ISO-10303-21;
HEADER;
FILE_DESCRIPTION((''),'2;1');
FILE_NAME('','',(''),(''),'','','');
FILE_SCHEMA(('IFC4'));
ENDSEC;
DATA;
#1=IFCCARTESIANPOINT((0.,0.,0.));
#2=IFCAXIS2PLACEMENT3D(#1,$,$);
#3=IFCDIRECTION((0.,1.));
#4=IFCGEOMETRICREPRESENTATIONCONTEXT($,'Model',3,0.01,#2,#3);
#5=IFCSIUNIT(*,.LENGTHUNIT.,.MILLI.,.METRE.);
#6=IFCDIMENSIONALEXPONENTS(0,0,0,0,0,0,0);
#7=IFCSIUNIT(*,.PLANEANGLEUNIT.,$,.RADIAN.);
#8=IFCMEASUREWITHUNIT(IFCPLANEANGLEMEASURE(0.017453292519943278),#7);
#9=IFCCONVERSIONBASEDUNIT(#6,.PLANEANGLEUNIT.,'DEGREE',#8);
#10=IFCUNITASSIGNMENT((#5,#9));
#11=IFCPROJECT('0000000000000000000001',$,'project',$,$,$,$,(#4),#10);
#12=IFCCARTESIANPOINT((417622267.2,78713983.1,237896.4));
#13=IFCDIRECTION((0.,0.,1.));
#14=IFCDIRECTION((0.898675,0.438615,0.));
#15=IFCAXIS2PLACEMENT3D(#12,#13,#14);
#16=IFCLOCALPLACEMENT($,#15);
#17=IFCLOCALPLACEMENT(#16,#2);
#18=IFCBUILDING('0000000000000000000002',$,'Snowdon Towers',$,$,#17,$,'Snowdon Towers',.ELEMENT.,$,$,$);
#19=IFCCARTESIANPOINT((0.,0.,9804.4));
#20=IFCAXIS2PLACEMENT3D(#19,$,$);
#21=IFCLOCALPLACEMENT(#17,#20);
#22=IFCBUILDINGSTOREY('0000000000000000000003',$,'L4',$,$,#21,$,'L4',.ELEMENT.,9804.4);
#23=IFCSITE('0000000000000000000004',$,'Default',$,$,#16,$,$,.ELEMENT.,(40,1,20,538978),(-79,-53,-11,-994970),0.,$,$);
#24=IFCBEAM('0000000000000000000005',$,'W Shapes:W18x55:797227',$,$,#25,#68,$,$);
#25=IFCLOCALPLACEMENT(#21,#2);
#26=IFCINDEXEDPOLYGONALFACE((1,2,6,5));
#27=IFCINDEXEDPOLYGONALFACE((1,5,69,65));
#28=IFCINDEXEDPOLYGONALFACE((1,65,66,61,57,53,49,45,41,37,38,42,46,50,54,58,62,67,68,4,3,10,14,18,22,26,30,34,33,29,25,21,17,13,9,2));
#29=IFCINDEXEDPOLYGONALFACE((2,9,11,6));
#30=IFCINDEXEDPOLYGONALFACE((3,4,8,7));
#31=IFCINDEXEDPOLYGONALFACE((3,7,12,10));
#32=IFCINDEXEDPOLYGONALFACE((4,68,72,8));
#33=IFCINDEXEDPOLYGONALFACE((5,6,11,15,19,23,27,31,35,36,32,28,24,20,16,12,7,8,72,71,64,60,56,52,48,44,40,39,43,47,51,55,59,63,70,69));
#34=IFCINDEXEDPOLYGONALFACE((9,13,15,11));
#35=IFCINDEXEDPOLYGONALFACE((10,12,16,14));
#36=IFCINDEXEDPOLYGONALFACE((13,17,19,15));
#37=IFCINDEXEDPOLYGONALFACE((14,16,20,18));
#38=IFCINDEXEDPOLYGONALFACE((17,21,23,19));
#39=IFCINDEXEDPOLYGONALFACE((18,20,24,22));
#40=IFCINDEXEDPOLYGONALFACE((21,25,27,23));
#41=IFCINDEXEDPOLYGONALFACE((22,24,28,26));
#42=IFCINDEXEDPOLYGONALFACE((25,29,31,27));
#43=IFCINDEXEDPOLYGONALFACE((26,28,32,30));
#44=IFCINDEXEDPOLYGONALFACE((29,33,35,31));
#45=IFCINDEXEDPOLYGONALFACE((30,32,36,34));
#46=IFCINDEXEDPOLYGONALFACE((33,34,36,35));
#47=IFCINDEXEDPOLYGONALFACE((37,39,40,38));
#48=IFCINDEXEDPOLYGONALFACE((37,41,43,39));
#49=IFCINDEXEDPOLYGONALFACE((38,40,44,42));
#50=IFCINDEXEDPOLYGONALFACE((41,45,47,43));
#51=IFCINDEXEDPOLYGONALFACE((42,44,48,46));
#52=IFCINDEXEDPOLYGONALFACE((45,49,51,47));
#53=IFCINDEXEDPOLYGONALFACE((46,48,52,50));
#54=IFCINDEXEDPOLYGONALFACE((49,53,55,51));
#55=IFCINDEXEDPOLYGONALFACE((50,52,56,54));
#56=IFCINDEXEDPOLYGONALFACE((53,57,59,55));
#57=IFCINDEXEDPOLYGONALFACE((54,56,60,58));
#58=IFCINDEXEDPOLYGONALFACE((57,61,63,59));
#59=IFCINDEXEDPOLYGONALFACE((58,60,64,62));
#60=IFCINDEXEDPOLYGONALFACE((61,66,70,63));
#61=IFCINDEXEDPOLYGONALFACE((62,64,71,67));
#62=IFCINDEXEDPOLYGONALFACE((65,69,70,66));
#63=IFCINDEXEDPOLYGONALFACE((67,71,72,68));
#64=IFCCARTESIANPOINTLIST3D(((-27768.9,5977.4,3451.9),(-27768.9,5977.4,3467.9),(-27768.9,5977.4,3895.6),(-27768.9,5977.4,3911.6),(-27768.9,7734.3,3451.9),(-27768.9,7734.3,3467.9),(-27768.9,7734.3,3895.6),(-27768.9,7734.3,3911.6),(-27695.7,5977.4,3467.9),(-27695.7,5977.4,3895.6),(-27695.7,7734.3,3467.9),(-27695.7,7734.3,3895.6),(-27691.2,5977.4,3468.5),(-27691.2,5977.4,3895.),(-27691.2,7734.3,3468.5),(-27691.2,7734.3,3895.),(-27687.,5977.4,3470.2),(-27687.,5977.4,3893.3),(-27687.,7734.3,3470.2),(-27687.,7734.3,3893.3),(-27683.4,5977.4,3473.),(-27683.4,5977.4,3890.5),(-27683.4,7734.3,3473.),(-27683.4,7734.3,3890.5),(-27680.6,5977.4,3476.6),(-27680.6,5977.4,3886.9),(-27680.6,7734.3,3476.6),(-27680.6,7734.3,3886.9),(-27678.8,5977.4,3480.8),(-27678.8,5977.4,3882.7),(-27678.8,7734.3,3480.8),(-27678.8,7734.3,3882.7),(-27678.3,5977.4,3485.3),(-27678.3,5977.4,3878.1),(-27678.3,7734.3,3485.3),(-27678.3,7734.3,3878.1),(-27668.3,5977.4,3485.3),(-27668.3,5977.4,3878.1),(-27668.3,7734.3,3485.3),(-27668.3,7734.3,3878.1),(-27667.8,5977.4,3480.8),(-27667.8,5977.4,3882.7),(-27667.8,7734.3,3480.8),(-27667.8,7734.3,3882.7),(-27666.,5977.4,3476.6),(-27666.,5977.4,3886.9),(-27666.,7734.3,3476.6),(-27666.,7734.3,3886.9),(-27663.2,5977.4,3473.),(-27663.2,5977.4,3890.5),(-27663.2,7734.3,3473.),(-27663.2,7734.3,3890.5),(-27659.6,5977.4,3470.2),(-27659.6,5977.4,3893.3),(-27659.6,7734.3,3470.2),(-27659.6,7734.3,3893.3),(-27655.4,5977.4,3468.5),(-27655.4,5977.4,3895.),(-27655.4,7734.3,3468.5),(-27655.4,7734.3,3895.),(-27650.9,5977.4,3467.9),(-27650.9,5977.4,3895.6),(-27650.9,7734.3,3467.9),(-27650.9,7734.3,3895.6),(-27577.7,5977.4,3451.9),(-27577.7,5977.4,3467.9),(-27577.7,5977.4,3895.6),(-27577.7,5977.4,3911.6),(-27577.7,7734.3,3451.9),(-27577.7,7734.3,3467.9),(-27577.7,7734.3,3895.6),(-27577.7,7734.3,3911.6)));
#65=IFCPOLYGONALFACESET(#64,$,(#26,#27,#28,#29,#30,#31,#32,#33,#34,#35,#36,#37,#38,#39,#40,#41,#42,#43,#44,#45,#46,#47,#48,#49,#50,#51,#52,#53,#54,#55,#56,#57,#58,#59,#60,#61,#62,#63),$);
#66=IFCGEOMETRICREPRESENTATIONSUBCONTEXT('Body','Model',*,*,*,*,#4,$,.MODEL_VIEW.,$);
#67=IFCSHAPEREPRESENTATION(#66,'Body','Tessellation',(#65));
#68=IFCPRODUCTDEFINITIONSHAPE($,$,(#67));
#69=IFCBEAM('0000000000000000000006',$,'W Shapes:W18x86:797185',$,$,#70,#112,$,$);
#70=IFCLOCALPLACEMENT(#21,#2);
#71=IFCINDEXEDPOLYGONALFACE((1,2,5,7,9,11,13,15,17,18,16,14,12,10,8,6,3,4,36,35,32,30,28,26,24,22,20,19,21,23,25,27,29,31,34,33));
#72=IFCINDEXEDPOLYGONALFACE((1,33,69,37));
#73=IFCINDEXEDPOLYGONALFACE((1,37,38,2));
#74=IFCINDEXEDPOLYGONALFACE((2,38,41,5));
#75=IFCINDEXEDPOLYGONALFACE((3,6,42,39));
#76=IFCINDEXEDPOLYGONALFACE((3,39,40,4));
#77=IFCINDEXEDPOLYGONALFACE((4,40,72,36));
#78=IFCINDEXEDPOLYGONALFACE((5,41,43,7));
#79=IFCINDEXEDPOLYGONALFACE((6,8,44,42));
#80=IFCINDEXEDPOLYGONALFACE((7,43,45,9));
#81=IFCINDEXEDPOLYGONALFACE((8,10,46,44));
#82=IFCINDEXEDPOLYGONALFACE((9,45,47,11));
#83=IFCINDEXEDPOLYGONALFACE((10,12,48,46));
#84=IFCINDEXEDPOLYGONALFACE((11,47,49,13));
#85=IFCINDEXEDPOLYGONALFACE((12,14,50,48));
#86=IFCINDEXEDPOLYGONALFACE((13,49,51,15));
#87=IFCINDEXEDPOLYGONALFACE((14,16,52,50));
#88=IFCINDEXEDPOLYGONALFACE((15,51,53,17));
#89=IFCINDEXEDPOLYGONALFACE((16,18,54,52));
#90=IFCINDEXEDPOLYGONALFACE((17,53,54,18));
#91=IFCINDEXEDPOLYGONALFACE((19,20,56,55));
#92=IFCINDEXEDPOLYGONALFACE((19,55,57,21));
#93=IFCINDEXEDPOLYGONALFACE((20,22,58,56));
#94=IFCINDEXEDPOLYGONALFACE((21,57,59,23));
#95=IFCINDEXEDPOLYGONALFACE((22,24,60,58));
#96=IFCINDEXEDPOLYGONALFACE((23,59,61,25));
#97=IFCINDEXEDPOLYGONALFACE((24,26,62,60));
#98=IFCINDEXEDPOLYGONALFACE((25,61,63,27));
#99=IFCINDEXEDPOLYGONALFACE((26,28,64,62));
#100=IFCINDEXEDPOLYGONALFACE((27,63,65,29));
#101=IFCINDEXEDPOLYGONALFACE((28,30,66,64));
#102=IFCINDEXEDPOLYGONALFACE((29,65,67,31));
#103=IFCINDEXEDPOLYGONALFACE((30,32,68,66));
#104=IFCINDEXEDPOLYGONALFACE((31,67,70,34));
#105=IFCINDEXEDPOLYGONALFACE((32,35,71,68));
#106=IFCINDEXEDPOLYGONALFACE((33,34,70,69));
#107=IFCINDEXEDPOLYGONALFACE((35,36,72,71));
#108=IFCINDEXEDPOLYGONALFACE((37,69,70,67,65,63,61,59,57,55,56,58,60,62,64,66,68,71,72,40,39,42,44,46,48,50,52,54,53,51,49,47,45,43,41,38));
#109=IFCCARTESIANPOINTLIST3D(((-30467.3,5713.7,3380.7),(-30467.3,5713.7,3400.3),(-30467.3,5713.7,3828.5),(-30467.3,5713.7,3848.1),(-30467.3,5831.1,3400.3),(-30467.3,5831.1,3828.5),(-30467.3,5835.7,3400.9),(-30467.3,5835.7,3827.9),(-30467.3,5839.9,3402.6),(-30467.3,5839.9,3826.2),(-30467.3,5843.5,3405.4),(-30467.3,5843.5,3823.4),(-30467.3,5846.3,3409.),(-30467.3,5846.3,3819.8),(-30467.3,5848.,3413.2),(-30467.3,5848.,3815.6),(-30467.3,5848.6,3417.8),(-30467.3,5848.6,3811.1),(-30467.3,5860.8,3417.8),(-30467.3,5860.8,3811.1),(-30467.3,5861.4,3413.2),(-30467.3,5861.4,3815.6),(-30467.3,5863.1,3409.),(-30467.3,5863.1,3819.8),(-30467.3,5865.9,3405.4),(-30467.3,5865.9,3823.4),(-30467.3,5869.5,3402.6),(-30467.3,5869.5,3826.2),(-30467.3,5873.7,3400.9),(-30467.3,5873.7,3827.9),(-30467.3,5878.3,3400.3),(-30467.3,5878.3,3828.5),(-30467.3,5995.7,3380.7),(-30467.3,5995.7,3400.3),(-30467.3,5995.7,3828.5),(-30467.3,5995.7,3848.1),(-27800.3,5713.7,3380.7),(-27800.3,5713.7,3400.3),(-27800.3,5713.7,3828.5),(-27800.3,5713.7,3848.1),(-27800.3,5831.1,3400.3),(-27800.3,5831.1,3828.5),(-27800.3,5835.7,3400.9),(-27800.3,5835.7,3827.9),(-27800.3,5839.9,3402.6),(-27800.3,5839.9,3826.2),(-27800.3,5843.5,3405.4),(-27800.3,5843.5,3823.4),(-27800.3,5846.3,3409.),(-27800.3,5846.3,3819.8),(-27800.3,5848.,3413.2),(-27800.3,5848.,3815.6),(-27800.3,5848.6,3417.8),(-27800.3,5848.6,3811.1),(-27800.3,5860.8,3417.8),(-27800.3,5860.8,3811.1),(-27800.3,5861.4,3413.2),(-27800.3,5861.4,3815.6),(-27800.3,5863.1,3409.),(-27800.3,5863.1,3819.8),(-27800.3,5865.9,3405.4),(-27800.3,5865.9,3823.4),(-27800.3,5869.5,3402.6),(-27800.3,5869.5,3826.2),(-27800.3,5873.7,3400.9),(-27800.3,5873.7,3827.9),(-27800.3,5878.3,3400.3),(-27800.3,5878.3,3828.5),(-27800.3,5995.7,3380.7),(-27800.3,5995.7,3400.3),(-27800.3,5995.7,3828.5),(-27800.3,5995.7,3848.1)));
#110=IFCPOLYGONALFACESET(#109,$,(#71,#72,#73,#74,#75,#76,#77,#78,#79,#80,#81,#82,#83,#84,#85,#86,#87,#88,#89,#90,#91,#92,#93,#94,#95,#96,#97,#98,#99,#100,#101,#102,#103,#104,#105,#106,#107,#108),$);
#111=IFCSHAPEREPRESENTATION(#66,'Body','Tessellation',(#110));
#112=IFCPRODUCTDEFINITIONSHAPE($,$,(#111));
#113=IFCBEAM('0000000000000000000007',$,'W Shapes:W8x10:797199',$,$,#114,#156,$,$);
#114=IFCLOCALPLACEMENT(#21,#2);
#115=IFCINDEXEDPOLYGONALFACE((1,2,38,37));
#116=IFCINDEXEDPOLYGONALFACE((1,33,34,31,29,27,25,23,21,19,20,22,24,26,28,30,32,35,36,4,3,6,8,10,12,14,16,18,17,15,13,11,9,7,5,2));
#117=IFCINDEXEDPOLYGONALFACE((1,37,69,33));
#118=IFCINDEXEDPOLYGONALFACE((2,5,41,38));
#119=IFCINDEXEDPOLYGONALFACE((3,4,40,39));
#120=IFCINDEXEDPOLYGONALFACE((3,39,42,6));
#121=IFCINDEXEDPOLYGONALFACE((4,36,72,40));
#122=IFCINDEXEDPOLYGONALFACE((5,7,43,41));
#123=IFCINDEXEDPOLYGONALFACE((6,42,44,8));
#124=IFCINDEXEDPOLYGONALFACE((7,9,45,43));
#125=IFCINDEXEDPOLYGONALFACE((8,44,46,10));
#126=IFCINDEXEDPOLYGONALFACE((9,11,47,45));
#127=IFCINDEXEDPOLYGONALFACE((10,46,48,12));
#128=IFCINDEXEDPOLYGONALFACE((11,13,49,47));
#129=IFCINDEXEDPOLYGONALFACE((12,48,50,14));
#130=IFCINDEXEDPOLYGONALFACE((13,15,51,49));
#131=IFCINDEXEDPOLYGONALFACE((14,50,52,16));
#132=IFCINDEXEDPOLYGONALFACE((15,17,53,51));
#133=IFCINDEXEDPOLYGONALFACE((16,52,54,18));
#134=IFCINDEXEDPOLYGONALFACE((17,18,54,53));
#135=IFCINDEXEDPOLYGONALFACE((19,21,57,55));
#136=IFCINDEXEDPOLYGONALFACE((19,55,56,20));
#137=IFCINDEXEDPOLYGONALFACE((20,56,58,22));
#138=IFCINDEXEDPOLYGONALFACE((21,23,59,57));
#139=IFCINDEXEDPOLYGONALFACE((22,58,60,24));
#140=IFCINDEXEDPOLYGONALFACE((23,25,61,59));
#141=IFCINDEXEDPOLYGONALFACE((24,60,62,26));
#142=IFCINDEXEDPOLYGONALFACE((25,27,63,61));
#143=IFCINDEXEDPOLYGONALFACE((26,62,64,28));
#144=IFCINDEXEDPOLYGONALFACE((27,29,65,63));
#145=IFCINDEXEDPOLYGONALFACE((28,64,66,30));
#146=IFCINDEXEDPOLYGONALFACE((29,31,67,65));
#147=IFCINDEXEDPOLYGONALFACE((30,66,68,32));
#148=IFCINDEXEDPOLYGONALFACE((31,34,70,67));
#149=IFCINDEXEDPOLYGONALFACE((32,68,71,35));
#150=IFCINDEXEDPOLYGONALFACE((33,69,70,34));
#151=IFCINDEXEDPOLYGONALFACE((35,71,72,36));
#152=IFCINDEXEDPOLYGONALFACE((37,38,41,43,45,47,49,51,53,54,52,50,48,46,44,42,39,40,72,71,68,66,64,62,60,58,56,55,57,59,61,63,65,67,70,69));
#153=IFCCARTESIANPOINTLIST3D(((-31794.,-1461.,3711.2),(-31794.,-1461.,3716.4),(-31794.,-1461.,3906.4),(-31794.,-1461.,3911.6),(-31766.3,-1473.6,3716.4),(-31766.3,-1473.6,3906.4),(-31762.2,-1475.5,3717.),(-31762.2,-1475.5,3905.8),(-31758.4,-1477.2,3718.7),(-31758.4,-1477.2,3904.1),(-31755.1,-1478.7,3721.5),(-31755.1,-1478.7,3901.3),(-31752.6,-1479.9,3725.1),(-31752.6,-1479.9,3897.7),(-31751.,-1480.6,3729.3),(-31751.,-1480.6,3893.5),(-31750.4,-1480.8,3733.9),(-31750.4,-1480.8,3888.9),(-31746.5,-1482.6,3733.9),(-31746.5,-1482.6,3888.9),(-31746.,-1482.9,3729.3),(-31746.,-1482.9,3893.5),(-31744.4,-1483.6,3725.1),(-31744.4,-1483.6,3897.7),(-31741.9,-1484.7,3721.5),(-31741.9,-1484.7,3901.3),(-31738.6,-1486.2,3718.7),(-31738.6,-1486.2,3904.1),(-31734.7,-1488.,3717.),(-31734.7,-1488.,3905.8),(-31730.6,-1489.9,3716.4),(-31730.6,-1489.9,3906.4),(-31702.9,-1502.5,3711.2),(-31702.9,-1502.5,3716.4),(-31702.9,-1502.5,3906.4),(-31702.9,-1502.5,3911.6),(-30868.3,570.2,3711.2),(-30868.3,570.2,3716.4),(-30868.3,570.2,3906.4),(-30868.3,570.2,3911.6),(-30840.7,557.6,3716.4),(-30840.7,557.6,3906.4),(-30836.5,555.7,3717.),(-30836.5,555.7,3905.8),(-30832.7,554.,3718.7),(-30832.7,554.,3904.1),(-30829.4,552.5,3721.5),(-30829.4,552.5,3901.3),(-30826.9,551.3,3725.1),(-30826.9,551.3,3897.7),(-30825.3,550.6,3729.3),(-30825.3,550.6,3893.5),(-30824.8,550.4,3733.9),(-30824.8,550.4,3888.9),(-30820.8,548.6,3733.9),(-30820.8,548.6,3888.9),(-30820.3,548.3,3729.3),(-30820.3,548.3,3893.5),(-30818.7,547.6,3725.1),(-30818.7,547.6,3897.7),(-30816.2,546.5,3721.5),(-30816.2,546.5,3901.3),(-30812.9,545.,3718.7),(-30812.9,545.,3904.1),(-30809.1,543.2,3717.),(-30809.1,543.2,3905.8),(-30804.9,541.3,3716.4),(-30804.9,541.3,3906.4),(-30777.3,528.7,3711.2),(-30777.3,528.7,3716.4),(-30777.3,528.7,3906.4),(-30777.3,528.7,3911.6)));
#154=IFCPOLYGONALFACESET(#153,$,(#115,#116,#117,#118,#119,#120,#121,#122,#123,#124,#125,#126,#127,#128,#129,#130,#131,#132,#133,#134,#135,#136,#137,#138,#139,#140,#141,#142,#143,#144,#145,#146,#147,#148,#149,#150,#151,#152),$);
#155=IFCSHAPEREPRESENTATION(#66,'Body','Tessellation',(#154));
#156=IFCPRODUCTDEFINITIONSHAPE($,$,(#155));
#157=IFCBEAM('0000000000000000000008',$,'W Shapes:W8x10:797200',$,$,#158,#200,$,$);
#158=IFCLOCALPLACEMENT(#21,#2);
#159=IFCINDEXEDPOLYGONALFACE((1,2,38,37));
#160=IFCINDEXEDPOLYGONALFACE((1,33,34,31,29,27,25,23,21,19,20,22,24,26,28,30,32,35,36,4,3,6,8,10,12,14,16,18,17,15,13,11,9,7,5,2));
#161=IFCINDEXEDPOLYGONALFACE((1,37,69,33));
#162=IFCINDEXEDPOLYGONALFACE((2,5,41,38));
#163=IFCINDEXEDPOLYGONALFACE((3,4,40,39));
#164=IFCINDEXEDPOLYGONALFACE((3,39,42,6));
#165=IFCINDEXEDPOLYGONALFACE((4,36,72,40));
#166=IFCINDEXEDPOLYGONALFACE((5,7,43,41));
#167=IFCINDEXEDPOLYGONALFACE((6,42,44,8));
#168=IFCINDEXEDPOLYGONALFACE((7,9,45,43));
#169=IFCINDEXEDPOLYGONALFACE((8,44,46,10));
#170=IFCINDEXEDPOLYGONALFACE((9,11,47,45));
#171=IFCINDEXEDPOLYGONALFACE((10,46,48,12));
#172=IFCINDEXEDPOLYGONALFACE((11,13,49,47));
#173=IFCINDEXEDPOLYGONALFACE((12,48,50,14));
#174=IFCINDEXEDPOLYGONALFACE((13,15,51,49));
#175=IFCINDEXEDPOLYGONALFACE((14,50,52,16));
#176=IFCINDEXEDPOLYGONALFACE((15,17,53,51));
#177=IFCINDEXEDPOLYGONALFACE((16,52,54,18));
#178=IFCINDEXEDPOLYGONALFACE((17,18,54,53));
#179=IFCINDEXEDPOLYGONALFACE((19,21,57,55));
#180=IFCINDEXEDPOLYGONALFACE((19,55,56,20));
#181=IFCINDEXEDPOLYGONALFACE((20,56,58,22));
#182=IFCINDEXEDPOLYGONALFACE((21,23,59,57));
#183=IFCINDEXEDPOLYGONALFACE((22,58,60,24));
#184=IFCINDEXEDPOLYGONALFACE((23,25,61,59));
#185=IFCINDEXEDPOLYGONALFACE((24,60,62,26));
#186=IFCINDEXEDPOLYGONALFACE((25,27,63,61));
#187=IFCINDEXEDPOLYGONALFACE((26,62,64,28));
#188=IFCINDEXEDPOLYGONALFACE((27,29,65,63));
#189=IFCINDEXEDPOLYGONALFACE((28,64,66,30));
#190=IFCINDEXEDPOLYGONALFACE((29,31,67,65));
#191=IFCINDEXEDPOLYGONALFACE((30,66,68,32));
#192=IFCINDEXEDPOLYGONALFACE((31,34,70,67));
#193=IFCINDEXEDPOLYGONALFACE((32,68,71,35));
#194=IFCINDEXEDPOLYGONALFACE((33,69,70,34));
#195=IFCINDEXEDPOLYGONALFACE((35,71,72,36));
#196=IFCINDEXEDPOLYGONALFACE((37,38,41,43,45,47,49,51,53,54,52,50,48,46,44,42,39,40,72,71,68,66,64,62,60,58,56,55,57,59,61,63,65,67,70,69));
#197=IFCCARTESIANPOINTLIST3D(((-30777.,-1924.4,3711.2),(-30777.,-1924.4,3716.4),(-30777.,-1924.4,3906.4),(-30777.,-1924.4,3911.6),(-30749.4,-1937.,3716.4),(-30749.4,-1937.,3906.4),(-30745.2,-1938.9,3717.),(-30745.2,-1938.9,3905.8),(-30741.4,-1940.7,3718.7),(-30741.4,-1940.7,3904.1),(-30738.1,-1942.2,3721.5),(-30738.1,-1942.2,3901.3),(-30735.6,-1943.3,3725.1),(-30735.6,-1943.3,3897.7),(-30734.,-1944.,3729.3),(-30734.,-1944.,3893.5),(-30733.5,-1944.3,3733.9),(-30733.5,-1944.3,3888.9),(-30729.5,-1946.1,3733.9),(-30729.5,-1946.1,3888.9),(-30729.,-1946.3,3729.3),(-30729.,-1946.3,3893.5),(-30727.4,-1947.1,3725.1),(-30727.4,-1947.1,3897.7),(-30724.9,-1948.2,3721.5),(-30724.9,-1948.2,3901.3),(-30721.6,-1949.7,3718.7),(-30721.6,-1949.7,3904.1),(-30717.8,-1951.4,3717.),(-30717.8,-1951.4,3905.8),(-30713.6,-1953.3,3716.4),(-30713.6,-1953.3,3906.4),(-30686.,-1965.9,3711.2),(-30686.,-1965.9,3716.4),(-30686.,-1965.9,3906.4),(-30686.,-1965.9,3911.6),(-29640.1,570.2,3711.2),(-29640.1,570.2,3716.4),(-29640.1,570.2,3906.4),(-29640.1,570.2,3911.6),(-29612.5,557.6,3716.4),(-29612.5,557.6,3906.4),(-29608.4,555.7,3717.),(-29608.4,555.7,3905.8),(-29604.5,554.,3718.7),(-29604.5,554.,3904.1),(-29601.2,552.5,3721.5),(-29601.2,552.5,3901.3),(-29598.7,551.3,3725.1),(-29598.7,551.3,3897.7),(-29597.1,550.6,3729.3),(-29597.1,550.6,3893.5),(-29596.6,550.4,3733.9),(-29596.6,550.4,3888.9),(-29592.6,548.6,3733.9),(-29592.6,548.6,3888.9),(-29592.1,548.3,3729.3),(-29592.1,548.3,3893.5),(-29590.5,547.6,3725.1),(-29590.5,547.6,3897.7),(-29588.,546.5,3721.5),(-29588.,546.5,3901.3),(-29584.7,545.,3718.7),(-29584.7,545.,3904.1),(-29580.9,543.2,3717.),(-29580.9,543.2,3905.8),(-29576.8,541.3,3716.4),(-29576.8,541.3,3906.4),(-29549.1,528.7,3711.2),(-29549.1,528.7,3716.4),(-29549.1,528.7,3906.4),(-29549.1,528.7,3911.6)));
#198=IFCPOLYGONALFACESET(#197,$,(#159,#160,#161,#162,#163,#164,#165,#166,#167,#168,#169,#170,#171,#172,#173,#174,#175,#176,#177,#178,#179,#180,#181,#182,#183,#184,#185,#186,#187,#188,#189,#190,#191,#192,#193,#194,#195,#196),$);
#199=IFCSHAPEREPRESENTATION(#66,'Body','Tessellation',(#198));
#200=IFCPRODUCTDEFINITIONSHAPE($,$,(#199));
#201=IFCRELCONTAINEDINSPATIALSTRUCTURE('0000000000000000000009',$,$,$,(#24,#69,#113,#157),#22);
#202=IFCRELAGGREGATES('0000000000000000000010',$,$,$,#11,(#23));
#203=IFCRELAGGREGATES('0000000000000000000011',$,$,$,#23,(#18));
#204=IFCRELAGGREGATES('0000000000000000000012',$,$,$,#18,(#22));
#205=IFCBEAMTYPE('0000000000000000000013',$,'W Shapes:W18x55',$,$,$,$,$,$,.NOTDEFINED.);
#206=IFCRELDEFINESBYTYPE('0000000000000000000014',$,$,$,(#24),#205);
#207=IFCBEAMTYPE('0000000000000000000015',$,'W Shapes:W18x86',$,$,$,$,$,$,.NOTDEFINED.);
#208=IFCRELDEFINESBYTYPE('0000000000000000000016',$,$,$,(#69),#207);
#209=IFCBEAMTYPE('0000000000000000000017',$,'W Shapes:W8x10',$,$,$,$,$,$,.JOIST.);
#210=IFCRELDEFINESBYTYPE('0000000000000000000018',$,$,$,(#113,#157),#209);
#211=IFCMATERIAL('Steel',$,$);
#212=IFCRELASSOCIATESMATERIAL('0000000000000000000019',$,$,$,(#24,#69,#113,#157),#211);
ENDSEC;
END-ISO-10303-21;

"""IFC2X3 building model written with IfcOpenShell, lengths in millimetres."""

from ifc_helpers import new_model, entity, si_unit, converted_unit, direction, frame, frame_2d, origin, place, context, subcontext, project, spatial, i_section, extrude, material, type_object, element, save


model = new_model("IFC2X3")

# Units and contexts
model_context = context("Model", 3, precision=0.01, world=origin(), true_north=direction((0.0, 1.0)))
body_context = subcontext(model_context, "Body", "Model", "MODEL_VIEW")
ifc_project = project(units=[si_unit("LENGTHUNIT", "METRE", prefix="MILLI"), converted_unit("PLANEANGLEUNIT", "DEGREE", entity("IfcPlaneAngleMeasure", 0.017453292519943278), si_unit("PLANEANGLEUNIT", "RADIAN"), dimensions=[0, 0, 0, 0, 0, 0, 0])], contexts=[model_context])

# Site, building, storey
site_placement = place(None, frame((417622267.2, 78713983.1, 237896.4), z_axis=(0.0, 0.0, 1.0), x_axis=(0.898675, 0.438615, 0.0)))
site = spatial("IfcSite", under=ifc_project, at=site_placement, Name="Default", CompositionType="ELEMENT", RefLatitude=(40, 1, 20, 538978), RefLongitude=(-79, -53, -11, -994970), RefElevation=0.0)
building_placement = place(site_placement, origin())
building = spatial("IfcBuilding", under=site, at=building_placement, Name="Snowdon Towers", LongName="Snowdon Towers", CompositionType="ELEMENT")
storey_placement = place(building_placement, frame((0.0, 0.0, 9804.4)))
storey = spatial("IfcBuildingStorey", under=building, at=storey_placement, Name="L4", LongName="L4", CompositionType="ELEMENT", Elevation=9804.4)

# Shared definitions
ifc_material_1 = material(Name="Steel")

# Beams
beam_type_1 = type_object("IfcBeamType", Name="W Shapes:W18x55", PredefinedType="NOTDEFINED")
beam_1_placement = place(storey_placement, frame((-27673.3, 5854.7, 3911.6), z_axis=(0.0, 0.0, 1.0), x_axis=(0.0, 1.0, 0.0)))
element("IfcBeam", 1, at=beam_1_placement, inside=storey, type_object=beam_type_1, material=ifc_material_1, Name="W Shapes:W18x55:797227", context=body_context, shape_type="SweptSolid", body=[
    extrude(i_section(OverallWidth=191.3, OverallDepth=459.7, WebThickness=9.9, FlangeThickness=16.0, FilletRadius=17.5, at=frame_2d((0.0, 0.0), x_axis=(0.0, 1.0))), frame((122.7, 0.0, -229.9), z_axis=(1.0, 0.0, 0.0), x_axis=(0.0, 0.0, -1.0)), (0.0, 0.0, 1.0), 1756.9),
])
beam_type_2 = type_object("IfcBeamType", Name="W Shapes:W18x86", PredefinedType="NOTDEFINED")
beam_2_placement = place(storey_placement, frame((-30467.3, 5854.7, 3911.6)))
element("IfcBeam", 2, at=beam_2_placement, inside=storey, type_object=beam_type_2, material=ifc_material_1, Name="W Shapes:W18x86:797185", context=body_context, shape_type="SweptSolid", body=[
    extrude(i_section(OverallWidth=281.9, OverallDepth=467.4, WebThickness=12.2, FlangeThickness=19.6, FilletRadius=17.5, at=frame_2d((0.0, 0.0), x_axis=(0.0, 1.0))), frame((0.0, 0.0, -297.2), z_axis=(1.0, 0.0, 0.0), x_axis=(0.0, 0.0, -1.0)), (0.0, 0.0, 1.0), 2667.0),
])
beam_type_3 = type_object("IfcBeamType", Name="W Shapes:W8x10", PredefinedType="JOIST")
beam_3_placement = place(storey_placement, frame((-31782.6, -1556.7, 3911.6), z_axis=(0.0, 0.0, 1.0), x_axis=(0.414693, 0.909961, 0.0)))
element("IfcBeam", 3, at=beam_3_placement, inside=storey, type_object=beam_type_3, material=ifc_material_1, Name="W Shapes:W8x10:797199", context=body_context, shape_type="SweptSolid", body=[
    extrude(i_section(OverallWidth=100.1, OverallDepth=200.4, WebThickness=4.3, FlangeThickness=5.2, FilletRadius=17.5, at=frame_2d((0.0, 0.0), x_axis=(0.0, 1.0))), frame((82.4, 0.0, -100.2), z_axis=(1.0, 0.0, 0.0), x_axis=(0.0, 0.0, -1.0)), (0.0, 0.0, 1.0), 2232.2),
])
beam_4_placement = place(storey_placement, frame((-30765.7, -2020.2, 3911.6), z_axis=(0.0, 0.0, 1.0), x_axis=(0.414693, 0.909961, 0.0)))
element("IfcBeam", 4, at=beam_4_placement, inside=storey, type_object=beam_type_3, material=ifc_material_1, Name="W Shapes:W8x10:797200", context=body_context, shape_type="SweptSolid", body=[
    extrude(i_section(OverallWidth=100.1, OverallDepth=200.4, WebThickness=4.3, FlangeThickness=5.2, FilletRadius=17.5, at=frame_2d((0.0, 0.0), x_axis=(0.0, 1.0))), frame((82.4, 0.0, -100.2), z_axis=(1.0, 0.0, 0.0), x_axis=(0.0, 0.0, -1.0)), (0.0, 0.0, 1.0), 2741.5),
])

save(model, "model.ifc")
